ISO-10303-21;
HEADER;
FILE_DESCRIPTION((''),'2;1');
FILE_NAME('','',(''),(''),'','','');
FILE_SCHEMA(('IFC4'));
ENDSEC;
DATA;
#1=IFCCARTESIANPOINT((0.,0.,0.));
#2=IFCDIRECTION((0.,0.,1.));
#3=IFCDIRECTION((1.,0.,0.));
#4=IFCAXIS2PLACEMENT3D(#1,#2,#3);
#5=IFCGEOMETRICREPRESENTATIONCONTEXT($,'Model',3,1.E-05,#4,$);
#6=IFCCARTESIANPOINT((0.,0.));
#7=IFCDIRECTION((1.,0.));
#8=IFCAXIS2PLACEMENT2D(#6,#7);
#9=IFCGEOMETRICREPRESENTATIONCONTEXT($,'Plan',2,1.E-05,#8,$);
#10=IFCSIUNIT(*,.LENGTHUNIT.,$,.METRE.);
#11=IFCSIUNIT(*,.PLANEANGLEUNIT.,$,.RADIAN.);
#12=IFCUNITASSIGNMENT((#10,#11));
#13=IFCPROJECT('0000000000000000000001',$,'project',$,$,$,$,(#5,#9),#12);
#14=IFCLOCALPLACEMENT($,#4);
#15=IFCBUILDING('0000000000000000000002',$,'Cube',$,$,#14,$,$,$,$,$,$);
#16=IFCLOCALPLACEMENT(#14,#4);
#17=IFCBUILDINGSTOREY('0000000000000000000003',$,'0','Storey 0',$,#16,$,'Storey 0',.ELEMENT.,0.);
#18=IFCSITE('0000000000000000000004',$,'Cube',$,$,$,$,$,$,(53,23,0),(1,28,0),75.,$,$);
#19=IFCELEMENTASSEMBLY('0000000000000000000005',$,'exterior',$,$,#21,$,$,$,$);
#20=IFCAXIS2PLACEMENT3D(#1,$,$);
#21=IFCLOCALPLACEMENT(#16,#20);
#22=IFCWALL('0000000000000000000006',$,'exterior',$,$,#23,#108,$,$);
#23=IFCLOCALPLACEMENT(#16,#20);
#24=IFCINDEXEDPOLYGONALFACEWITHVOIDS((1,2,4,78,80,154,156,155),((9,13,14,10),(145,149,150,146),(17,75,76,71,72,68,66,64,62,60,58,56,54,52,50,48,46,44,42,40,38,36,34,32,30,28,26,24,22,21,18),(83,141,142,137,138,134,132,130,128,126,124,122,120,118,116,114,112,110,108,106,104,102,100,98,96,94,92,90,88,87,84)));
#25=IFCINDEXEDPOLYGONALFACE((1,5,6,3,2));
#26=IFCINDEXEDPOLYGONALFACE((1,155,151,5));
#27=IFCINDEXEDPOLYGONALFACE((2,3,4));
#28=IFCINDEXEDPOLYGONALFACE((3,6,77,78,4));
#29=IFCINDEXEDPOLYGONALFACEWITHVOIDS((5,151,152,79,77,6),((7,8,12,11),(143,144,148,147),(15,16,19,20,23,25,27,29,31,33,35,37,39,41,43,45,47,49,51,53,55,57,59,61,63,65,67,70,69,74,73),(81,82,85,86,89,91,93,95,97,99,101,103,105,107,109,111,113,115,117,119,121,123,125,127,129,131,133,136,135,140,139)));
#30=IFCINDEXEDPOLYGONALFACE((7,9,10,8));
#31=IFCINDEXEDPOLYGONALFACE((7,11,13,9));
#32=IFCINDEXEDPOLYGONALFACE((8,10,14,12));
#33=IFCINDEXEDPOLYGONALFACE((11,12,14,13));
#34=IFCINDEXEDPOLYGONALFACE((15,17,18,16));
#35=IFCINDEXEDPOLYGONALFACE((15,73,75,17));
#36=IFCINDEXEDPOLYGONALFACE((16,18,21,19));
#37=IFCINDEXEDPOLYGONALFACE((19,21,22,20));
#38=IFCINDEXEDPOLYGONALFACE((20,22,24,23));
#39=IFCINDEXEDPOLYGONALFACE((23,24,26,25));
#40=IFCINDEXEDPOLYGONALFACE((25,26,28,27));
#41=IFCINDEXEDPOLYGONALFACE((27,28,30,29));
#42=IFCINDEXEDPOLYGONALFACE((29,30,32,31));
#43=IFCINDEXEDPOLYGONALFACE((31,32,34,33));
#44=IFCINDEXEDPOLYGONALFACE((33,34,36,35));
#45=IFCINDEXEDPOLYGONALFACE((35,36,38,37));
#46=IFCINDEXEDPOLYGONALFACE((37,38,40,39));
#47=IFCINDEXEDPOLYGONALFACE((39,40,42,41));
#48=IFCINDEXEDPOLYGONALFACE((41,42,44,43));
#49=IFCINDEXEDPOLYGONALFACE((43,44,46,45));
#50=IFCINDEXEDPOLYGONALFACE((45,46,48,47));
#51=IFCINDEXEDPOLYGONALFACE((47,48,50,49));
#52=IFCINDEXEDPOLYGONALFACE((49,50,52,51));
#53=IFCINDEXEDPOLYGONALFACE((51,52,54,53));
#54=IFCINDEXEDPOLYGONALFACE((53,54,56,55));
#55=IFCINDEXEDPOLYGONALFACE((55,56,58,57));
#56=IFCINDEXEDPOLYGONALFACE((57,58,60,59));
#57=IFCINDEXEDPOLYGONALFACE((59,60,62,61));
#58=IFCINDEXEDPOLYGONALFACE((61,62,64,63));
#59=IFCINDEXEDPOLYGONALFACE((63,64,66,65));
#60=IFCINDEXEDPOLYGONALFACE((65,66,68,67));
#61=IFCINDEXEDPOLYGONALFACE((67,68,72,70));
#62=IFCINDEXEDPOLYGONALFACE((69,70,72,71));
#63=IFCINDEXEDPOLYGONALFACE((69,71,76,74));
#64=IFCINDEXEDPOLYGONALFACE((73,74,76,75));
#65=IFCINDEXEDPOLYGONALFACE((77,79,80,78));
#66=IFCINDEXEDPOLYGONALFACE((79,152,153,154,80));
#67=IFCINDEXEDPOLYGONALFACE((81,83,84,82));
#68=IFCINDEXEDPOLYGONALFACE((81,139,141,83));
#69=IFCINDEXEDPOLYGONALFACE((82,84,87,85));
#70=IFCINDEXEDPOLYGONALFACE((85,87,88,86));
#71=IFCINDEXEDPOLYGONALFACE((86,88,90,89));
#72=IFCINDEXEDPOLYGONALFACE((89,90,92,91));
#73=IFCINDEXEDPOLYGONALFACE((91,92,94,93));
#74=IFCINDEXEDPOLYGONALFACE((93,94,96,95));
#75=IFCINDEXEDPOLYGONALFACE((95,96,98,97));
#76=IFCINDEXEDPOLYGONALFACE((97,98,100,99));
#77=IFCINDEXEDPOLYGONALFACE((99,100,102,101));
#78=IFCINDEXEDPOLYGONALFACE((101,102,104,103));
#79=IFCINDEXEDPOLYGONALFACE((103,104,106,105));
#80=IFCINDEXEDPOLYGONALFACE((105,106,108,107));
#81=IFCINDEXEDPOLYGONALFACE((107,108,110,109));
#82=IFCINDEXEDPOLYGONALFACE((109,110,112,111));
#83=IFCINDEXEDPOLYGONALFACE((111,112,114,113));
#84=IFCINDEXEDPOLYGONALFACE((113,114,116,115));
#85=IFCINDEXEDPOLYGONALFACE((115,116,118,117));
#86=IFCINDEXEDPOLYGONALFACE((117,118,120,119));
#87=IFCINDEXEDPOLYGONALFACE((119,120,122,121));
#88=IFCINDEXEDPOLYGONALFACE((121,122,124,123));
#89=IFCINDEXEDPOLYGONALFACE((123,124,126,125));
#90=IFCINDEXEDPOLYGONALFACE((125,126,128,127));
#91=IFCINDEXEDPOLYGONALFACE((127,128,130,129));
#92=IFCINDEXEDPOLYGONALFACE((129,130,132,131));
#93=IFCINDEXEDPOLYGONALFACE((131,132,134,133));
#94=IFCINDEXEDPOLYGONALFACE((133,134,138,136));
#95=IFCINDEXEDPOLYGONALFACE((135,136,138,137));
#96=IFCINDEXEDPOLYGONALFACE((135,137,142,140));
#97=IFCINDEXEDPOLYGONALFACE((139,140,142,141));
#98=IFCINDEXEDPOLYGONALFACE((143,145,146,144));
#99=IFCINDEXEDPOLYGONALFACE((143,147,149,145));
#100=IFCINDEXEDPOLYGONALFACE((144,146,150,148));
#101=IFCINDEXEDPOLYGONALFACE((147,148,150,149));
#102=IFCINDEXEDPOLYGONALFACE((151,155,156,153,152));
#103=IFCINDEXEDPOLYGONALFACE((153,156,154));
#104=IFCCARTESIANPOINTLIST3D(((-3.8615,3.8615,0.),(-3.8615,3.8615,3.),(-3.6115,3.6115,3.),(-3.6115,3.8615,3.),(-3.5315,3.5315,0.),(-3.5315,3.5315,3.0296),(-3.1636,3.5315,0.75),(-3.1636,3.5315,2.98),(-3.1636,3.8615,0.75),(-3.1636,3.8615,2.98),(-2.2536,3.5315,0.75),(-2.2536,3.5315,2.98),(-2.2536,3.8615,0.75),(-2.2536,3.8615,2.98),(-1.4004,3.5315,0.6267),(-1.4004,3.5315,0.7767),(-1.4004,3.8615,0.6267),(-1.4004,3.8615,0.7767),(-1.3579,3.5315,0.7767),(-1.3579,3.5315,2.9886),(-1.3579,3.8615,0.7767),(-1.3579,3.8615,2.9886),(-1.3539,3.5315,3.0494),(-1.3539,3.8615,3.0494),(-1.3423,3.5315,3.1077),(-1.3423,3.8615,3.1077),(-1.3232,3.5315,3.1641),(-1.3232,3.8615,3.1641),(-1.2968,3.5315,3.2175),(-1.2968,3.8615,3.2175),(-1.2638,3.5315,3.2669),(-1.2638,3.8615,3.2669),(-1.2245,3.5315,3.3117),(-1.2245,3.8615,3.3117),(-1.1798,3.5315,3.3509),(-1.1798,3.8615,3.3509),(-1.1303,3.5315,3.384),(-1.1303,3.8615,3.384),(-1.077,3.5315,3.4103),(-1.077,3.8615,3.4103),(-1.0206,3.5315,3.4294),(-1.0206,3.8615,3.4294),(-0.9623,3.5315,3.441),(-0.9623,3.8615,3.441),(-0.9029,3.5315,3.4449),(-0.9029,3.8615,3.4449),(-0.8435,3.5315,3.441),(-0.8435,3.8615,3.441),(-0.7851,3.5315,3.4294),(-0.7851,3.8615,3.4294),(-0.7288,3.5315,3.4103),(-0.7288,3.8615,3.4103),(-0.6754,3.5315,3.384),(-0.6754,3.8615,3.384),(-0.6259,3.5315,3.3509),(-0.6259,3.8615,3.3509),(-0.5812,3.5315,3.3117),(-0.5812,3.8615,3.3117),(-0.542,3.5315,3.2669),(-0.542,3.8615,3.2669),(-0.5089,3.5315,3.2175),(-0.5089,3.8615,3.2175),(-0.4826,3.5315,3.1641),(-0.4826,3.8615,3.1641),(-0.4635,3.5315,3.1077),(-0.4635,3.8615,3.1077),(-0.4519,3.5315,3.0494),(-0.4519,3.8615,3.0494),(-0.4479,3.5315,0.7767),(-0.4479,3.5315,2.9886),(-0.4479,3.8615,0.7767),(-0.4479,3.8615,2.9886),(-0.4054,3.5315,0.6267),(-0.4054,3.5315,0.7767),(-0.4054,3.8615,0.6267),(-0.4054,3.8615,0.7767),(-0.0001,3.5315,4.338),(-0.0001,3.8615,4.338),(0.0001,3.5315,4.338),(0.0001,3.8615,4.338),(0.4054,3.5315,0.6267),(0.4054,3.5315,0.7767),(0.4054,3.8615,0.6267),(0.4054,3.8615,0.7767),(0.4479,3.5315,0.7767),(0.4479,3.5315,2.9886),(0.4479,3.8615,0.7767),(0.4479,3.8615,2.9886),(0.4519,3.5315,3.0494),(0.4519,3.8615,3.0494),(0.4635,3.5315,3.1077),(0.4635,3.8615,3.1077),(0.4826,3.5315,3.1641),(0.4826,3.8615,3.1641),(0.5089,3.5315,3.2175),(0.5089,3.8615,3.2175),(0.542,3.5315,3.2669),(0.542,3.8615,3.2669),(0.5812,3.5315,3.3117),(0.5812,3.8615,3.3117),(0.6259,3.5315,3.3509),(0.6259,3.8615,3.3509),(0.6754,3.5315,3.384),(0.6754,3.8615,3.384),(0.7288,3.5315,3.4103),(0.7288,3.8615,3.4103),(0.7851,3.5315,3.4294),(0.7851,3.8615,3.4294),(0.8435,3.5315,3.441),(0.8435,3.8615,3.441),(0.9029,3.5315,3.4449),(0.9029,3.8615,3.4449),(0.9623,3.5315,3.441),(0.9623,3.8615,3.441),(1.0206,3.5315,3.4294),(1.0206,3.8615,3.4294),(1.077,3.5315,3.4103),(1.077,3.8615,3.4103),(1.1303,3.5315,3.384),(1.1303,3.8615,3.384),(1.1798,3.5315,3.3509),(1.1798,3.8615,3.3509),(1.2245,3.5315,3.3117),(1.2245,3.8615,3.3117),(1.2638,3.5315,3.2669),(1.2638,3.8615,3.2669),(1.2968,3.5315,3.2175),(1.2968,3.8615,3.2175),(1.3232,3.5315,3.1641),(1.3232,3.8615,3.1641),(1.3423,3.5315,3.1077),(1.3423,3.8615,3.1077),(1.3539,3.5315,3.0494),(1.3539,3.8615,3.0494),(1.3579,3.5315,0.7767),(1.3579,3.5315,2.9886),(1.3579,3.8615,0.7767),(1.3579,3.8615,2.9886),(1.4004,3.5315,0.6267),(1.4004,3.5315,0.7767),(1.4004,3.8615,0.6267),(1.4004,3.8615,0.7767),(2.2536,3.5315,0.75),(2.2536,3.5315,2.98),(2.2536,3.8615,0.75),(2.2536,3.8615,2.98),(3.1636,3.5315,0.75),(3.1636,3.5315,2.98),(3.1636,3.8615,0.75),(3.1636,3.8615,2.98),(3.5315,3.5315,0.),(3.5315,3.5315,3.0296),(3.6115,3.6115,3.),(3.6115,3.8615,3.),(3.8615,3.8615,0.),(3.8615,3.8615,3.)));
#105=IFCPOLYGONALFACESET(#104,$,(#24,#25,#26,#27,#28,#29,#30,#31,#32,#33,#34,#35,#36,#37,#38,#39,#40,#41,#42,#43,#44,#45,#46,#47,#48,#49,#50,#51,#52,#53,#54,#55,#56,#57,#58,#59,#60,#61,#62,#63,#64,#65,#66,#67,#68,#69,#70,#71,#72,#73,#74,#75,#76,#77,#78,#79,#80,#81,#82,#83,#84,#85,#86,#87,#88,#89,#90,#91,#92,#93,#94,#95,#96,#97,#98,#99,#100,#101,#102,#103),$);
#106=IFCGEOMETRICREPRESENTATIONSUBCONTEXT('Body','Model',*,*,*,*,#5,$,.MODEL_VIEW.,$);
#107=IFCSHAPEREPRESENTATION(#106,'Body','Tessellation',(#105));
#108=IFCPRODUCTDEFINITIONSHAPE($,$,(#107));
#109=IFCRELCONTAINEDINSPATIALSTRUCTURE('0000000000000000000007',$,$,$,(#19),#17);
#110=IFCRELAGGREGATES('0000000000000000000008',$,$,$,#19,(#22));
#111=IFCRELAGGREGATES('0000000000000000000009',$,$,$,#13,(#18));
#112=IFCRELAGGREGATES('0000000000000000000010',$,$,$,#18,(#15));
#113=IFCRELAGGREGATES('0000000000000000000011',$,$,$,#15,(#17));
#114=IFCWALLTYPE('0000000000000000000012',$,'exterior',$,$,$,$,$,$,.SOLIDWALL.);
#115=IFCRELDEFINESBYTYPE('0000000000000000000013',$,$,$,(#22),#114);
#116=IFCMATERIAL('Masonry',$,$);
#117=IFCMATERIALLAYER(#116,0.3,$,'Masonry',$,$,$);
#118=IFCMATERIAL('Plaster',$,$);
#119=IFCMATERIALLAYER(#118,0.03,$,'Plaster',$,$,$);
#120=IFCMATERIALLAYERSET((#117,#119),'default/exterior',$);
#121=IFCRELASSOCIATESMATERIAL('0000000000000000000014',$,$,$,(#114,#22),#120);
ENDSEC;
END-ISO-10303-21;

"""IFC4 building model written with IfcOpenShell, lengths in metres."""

from ifc_helpers import new_model, si_unit, frame, origin, origin_with_axes, origin_2d_with_axis, place, context, subcontext, project, spatial, polyline, outline, extrude, clip, bounded_halfspace, material, layer, layer_set, layer_usage, type_object, element, aggregate, save


model = new_model("IFC4")

# Units and contexts
model_context = context("Model", 3, precision=1e-05, world=origin_with_axes())
plan_context = context("Plan", 2, precision=1e-05, world=origin_2d_with_axis())
body_context = subcontext(model_context, "Body", "Model", "MODEL_VIEW")
ifc_project = project(units=[si_unit("LENGTHUNIT", "METRE"), si_unit("PLANEANGLEUNIT", "RADIAN")], contexts=[model_context, plan_context])

# Site, building, storey
site = spatial("IfcSite", under=ifc_project, Name="Cube", RefLatitude=(53, 23, 0), RefLongitude=(1, 28, 0), RefElevation=75.0)
building_placement = place(None, origin_with_axes())
building = spatial("IfcBuilding", under=site, at=building_placement, Name="Cube")
storey_placement = place(building_placement, origin_with_axes())
storey = spatial("IfcBuildingStorey", under=building, at=storey_placement, Name="0", Description="Storey 0", LongName="Storey 0", CompositionType="ELEMENT", Elevation=0.0)

# Element assembly, wall, openings
assembly_1_placement = place(storey_placement, frame((3.6115, 3.6115, 0.0), z_axis=(0.0, 0.0, 1.0), x_axis=(-1.0, 0.0, 0.0)))
assembly_1 = element("IfcElementAssembly", 1, at=assembly_1_placement, inside=storey, Name="exterior")
ifc_material_1 = material(Name="Masonry")
ifc_layer_1 = layer(ifc_material_1, 0.3, Name="Masonry")
ifc_material_2 = material(Name="Plaster")
ifc_layer_2 = layer(ifc_material_2, 0.03, Name="Plaster")
ifc_layer_set_1 = layer_set([ifc_layer_1, ifc_layer_2], Name="default/exterior")
ifc_layer_usage_1 = layer_usage(ifc_layer_set_1, "AXIS2", "POSITIVE", -0.25)
wall_type = type_object("IfcWallType", Name="exterior", PredefinedType="SOLIDWALL", material=ifc_layer_set_1)
wall_1_placement = place(assembly_1_placement, origin_with_axes())
wall_1 = element("IfcWall", 2, at=wall_1_placement, type_object=wall_type, material=ifc_layer_usage_1, Name="exterior", context=body_context, shape_type="Clipping", body=[
    clip(clip(clip(clip(extrude(outline(polyline([(0.08, 0.08), (-0.25, -0.25), (7.473, -0.25), (7.143, 0.08), (0.08, 0.08)])), origin(), (0.0, 0.0, 1.0), 4.338), bounded_halfspace(frame((7.223, 0.0, 3.0), z_axis=(0.347413, 0.0, 0.937712), x_axis=(0.0, -1.0, 0.0)), False, origin(), polyline([(7.223, -1.0), (3.6115, -1.0), (3.6115, 1.0), (7.223, 1.0), (7.223, -1.0)]))), bounded_halfspace(frame((7.223, 0.0, 3.0), z_axis=(0.0, 0.0, 1.0), x_axis=(0.0, 1.0, 0.0)), False, origin(), polyline([(7.223, 1.0), (8.223, 1.0), (8.223, -1.0), (7.223, -1.0), (7.223, 1.0)]))), bounded_halfspace(frame((3.6115, 0.0, 4.338), z_axis=(-0.347413, 0.0, 0.937712), x_axis=(0.0, -1.0, 0.0)), False, origin(), polyline([(3.6115, -1.0), (0.0, -1.0), (0.0, 1.0), (3.6115, 1.0), (3.6115, -1.0)]))), bounded_halfspace(frame((0.0, 0.0, 3.0), z_axis=(0.0, 0.0, 1.0), x_axis=(0.0, -1.0, 0.0)), False, origin(), polyline([(0.0, -1.0), (-1.0, -1.0), (-1.0, 1.0), (0.0, 1.0), (0.0, -1.0)]))),
])
opening_1_placement = place(wall_1_placement, frame((0.4479, -0.25, 0.75), z_axis=(0.0, 0.0, 1.0), x_axis=(1.0, 0.0, 0.0)))
element("IfcOpeningElement", 3, at=opening_1_placement, cuts=wall_1, PredefinedType="OPENING", context=body_context, shape_type="SweptSolid", body=[
    extrude(outline(polyline([(0.0, -0.02), (0.91, -0.02), (0.91, 0.35), (0.0, 0.35), (0.0, -0.02)])), origin(), (0.0, 0.0, 1.0), 2.23),
])
opening_2_placement = place(wall_1_placement, frame((2.2536, -0.25, 0.75), z_axis=(0.0, 0.0, 1.0), x_axis=(1.0, 0.0, 0.0)))
element("IfcOpeningElement", 4, at=opening_2_placement, cuts=wall_1, PredefinedType="OPENING", context=body_context, shape_type="SweptSolid", body=[
    extrude(outline(polyline([(0.1333, 2.5617), (0.1781, 2.6009), (0.2275, 2.634), (0.2809, 2.6603), (0.3373, 2.6794), (0.3956, 2.691), (0.455, 2.6949), (0.5144, 2.691), (0.5727, 2.6794), (0.6291, 2.6603), (0.6825, 2.634), (0.7319, 2.6009), (0.7767, 2.5617), (0.8159, 2.5169), (0.849, 2.4675), (0.8753, 2.4141), (0.8944, 2.3577), (0.906, 2.2994), (0.91, 2.2386), (0.91, 2.2069), (0.91, 0.0267), (0.9525, 0.0267), (0.9525, -0.1233), (-0.0425, -0.1233), (-0.0425, 0.0267), (0.0, 0.0267), (0.0, 2.2069), (0.0, 2.2386), (0.004, 2.2994), (0.0156, 2.3577), (0.0347, 2.4141), (0.061, 2.4675), (0.0941, 2.5169), (0.1333, 2.5617)])), frame((0.0, -0.02, 0.0), z_axis=(0.0, -1.0, 0.0), x_axis=(1.0, 0.0, 0.0)), (0.0, 0.0, -1.0), 0.37),
])
opening_3_placement = place(wall_1_placement, frame((4.0594, -0.25, 0.75), z_axis=(0.0, 0.0, 1.0), x_axis=(1.0, 0.0, 0.0)))
element("IfcOpeningElement", 5, at=opening_3_placement, cuts=wall_1, PredefinedType="OPENING", context=body_context, shape_type="SweptSolid", body=[
    extrude(outline(polyline([(0.1333, 2.5617), (0.1781, 2.6009), (0.2275, 2.634), (0.2809, 2.6603), (0.3373, 2.6794), (0.3956, 2.691), (0.455, 2.6949), (0.5144, 2.691), (0.5727, 2.6794), (0.6291, 2.6603), (0.6825, 2.634), (0.7319, 2.6009), (0.7767, 2.5617), (0.8159, 2.5169), (0.849, 2.4675), (0.8753, 2.4141), (0.8944, 2.3577), (0.906, 2.2994), (0.91, 2.2386), (0.91, 2.2069), (0.91, 0.0267), (0.9525, 0.0267), (0.9525, -0.1233), (-0.0425, -0.1233), (-0.0425, 0.0267), (0.0, 0.0267), (0.0, 2.2069), (0.0, 2.2386), (0.004, 2.2994), (0.0156, 2.3577), (0.0347, 2.4141), (0.061, 2.4675), (0.0941, 2.5169), (0.1333, 2.5617)])), frame((0.0, -0.02, 0.0), z_axis=(0.0, -1.0, 0.0), x_axis=(1.0, 0.0, 0.0)), (0.0, 0.0, -1.0), 0.37),
])
opening_4_placement = place(wall_1_placement, frame((5.8651, -0.25, 0.75), z_axis=(0.0, 0.0, 1.0), x_axis=(1.0, 0.0, 0.0)))
element("IfcOpeningElement", 6, at=opening_4_placement, cuts=wall_1, PredefinedType="OPENING", context=body_context, shape_type="SweptSolid", body=[
    extrude(outline(polyline([(0.0, -0.02), (0.91, -0.02), (0.91, 0.35), (0.0, 0.35), (0.0, -0.02)])), origin(), (0.0, 0.0, 1.0), 2.23),
])
aggregate(assembly_1, [wall_1])

save(model, "model.ifc")
